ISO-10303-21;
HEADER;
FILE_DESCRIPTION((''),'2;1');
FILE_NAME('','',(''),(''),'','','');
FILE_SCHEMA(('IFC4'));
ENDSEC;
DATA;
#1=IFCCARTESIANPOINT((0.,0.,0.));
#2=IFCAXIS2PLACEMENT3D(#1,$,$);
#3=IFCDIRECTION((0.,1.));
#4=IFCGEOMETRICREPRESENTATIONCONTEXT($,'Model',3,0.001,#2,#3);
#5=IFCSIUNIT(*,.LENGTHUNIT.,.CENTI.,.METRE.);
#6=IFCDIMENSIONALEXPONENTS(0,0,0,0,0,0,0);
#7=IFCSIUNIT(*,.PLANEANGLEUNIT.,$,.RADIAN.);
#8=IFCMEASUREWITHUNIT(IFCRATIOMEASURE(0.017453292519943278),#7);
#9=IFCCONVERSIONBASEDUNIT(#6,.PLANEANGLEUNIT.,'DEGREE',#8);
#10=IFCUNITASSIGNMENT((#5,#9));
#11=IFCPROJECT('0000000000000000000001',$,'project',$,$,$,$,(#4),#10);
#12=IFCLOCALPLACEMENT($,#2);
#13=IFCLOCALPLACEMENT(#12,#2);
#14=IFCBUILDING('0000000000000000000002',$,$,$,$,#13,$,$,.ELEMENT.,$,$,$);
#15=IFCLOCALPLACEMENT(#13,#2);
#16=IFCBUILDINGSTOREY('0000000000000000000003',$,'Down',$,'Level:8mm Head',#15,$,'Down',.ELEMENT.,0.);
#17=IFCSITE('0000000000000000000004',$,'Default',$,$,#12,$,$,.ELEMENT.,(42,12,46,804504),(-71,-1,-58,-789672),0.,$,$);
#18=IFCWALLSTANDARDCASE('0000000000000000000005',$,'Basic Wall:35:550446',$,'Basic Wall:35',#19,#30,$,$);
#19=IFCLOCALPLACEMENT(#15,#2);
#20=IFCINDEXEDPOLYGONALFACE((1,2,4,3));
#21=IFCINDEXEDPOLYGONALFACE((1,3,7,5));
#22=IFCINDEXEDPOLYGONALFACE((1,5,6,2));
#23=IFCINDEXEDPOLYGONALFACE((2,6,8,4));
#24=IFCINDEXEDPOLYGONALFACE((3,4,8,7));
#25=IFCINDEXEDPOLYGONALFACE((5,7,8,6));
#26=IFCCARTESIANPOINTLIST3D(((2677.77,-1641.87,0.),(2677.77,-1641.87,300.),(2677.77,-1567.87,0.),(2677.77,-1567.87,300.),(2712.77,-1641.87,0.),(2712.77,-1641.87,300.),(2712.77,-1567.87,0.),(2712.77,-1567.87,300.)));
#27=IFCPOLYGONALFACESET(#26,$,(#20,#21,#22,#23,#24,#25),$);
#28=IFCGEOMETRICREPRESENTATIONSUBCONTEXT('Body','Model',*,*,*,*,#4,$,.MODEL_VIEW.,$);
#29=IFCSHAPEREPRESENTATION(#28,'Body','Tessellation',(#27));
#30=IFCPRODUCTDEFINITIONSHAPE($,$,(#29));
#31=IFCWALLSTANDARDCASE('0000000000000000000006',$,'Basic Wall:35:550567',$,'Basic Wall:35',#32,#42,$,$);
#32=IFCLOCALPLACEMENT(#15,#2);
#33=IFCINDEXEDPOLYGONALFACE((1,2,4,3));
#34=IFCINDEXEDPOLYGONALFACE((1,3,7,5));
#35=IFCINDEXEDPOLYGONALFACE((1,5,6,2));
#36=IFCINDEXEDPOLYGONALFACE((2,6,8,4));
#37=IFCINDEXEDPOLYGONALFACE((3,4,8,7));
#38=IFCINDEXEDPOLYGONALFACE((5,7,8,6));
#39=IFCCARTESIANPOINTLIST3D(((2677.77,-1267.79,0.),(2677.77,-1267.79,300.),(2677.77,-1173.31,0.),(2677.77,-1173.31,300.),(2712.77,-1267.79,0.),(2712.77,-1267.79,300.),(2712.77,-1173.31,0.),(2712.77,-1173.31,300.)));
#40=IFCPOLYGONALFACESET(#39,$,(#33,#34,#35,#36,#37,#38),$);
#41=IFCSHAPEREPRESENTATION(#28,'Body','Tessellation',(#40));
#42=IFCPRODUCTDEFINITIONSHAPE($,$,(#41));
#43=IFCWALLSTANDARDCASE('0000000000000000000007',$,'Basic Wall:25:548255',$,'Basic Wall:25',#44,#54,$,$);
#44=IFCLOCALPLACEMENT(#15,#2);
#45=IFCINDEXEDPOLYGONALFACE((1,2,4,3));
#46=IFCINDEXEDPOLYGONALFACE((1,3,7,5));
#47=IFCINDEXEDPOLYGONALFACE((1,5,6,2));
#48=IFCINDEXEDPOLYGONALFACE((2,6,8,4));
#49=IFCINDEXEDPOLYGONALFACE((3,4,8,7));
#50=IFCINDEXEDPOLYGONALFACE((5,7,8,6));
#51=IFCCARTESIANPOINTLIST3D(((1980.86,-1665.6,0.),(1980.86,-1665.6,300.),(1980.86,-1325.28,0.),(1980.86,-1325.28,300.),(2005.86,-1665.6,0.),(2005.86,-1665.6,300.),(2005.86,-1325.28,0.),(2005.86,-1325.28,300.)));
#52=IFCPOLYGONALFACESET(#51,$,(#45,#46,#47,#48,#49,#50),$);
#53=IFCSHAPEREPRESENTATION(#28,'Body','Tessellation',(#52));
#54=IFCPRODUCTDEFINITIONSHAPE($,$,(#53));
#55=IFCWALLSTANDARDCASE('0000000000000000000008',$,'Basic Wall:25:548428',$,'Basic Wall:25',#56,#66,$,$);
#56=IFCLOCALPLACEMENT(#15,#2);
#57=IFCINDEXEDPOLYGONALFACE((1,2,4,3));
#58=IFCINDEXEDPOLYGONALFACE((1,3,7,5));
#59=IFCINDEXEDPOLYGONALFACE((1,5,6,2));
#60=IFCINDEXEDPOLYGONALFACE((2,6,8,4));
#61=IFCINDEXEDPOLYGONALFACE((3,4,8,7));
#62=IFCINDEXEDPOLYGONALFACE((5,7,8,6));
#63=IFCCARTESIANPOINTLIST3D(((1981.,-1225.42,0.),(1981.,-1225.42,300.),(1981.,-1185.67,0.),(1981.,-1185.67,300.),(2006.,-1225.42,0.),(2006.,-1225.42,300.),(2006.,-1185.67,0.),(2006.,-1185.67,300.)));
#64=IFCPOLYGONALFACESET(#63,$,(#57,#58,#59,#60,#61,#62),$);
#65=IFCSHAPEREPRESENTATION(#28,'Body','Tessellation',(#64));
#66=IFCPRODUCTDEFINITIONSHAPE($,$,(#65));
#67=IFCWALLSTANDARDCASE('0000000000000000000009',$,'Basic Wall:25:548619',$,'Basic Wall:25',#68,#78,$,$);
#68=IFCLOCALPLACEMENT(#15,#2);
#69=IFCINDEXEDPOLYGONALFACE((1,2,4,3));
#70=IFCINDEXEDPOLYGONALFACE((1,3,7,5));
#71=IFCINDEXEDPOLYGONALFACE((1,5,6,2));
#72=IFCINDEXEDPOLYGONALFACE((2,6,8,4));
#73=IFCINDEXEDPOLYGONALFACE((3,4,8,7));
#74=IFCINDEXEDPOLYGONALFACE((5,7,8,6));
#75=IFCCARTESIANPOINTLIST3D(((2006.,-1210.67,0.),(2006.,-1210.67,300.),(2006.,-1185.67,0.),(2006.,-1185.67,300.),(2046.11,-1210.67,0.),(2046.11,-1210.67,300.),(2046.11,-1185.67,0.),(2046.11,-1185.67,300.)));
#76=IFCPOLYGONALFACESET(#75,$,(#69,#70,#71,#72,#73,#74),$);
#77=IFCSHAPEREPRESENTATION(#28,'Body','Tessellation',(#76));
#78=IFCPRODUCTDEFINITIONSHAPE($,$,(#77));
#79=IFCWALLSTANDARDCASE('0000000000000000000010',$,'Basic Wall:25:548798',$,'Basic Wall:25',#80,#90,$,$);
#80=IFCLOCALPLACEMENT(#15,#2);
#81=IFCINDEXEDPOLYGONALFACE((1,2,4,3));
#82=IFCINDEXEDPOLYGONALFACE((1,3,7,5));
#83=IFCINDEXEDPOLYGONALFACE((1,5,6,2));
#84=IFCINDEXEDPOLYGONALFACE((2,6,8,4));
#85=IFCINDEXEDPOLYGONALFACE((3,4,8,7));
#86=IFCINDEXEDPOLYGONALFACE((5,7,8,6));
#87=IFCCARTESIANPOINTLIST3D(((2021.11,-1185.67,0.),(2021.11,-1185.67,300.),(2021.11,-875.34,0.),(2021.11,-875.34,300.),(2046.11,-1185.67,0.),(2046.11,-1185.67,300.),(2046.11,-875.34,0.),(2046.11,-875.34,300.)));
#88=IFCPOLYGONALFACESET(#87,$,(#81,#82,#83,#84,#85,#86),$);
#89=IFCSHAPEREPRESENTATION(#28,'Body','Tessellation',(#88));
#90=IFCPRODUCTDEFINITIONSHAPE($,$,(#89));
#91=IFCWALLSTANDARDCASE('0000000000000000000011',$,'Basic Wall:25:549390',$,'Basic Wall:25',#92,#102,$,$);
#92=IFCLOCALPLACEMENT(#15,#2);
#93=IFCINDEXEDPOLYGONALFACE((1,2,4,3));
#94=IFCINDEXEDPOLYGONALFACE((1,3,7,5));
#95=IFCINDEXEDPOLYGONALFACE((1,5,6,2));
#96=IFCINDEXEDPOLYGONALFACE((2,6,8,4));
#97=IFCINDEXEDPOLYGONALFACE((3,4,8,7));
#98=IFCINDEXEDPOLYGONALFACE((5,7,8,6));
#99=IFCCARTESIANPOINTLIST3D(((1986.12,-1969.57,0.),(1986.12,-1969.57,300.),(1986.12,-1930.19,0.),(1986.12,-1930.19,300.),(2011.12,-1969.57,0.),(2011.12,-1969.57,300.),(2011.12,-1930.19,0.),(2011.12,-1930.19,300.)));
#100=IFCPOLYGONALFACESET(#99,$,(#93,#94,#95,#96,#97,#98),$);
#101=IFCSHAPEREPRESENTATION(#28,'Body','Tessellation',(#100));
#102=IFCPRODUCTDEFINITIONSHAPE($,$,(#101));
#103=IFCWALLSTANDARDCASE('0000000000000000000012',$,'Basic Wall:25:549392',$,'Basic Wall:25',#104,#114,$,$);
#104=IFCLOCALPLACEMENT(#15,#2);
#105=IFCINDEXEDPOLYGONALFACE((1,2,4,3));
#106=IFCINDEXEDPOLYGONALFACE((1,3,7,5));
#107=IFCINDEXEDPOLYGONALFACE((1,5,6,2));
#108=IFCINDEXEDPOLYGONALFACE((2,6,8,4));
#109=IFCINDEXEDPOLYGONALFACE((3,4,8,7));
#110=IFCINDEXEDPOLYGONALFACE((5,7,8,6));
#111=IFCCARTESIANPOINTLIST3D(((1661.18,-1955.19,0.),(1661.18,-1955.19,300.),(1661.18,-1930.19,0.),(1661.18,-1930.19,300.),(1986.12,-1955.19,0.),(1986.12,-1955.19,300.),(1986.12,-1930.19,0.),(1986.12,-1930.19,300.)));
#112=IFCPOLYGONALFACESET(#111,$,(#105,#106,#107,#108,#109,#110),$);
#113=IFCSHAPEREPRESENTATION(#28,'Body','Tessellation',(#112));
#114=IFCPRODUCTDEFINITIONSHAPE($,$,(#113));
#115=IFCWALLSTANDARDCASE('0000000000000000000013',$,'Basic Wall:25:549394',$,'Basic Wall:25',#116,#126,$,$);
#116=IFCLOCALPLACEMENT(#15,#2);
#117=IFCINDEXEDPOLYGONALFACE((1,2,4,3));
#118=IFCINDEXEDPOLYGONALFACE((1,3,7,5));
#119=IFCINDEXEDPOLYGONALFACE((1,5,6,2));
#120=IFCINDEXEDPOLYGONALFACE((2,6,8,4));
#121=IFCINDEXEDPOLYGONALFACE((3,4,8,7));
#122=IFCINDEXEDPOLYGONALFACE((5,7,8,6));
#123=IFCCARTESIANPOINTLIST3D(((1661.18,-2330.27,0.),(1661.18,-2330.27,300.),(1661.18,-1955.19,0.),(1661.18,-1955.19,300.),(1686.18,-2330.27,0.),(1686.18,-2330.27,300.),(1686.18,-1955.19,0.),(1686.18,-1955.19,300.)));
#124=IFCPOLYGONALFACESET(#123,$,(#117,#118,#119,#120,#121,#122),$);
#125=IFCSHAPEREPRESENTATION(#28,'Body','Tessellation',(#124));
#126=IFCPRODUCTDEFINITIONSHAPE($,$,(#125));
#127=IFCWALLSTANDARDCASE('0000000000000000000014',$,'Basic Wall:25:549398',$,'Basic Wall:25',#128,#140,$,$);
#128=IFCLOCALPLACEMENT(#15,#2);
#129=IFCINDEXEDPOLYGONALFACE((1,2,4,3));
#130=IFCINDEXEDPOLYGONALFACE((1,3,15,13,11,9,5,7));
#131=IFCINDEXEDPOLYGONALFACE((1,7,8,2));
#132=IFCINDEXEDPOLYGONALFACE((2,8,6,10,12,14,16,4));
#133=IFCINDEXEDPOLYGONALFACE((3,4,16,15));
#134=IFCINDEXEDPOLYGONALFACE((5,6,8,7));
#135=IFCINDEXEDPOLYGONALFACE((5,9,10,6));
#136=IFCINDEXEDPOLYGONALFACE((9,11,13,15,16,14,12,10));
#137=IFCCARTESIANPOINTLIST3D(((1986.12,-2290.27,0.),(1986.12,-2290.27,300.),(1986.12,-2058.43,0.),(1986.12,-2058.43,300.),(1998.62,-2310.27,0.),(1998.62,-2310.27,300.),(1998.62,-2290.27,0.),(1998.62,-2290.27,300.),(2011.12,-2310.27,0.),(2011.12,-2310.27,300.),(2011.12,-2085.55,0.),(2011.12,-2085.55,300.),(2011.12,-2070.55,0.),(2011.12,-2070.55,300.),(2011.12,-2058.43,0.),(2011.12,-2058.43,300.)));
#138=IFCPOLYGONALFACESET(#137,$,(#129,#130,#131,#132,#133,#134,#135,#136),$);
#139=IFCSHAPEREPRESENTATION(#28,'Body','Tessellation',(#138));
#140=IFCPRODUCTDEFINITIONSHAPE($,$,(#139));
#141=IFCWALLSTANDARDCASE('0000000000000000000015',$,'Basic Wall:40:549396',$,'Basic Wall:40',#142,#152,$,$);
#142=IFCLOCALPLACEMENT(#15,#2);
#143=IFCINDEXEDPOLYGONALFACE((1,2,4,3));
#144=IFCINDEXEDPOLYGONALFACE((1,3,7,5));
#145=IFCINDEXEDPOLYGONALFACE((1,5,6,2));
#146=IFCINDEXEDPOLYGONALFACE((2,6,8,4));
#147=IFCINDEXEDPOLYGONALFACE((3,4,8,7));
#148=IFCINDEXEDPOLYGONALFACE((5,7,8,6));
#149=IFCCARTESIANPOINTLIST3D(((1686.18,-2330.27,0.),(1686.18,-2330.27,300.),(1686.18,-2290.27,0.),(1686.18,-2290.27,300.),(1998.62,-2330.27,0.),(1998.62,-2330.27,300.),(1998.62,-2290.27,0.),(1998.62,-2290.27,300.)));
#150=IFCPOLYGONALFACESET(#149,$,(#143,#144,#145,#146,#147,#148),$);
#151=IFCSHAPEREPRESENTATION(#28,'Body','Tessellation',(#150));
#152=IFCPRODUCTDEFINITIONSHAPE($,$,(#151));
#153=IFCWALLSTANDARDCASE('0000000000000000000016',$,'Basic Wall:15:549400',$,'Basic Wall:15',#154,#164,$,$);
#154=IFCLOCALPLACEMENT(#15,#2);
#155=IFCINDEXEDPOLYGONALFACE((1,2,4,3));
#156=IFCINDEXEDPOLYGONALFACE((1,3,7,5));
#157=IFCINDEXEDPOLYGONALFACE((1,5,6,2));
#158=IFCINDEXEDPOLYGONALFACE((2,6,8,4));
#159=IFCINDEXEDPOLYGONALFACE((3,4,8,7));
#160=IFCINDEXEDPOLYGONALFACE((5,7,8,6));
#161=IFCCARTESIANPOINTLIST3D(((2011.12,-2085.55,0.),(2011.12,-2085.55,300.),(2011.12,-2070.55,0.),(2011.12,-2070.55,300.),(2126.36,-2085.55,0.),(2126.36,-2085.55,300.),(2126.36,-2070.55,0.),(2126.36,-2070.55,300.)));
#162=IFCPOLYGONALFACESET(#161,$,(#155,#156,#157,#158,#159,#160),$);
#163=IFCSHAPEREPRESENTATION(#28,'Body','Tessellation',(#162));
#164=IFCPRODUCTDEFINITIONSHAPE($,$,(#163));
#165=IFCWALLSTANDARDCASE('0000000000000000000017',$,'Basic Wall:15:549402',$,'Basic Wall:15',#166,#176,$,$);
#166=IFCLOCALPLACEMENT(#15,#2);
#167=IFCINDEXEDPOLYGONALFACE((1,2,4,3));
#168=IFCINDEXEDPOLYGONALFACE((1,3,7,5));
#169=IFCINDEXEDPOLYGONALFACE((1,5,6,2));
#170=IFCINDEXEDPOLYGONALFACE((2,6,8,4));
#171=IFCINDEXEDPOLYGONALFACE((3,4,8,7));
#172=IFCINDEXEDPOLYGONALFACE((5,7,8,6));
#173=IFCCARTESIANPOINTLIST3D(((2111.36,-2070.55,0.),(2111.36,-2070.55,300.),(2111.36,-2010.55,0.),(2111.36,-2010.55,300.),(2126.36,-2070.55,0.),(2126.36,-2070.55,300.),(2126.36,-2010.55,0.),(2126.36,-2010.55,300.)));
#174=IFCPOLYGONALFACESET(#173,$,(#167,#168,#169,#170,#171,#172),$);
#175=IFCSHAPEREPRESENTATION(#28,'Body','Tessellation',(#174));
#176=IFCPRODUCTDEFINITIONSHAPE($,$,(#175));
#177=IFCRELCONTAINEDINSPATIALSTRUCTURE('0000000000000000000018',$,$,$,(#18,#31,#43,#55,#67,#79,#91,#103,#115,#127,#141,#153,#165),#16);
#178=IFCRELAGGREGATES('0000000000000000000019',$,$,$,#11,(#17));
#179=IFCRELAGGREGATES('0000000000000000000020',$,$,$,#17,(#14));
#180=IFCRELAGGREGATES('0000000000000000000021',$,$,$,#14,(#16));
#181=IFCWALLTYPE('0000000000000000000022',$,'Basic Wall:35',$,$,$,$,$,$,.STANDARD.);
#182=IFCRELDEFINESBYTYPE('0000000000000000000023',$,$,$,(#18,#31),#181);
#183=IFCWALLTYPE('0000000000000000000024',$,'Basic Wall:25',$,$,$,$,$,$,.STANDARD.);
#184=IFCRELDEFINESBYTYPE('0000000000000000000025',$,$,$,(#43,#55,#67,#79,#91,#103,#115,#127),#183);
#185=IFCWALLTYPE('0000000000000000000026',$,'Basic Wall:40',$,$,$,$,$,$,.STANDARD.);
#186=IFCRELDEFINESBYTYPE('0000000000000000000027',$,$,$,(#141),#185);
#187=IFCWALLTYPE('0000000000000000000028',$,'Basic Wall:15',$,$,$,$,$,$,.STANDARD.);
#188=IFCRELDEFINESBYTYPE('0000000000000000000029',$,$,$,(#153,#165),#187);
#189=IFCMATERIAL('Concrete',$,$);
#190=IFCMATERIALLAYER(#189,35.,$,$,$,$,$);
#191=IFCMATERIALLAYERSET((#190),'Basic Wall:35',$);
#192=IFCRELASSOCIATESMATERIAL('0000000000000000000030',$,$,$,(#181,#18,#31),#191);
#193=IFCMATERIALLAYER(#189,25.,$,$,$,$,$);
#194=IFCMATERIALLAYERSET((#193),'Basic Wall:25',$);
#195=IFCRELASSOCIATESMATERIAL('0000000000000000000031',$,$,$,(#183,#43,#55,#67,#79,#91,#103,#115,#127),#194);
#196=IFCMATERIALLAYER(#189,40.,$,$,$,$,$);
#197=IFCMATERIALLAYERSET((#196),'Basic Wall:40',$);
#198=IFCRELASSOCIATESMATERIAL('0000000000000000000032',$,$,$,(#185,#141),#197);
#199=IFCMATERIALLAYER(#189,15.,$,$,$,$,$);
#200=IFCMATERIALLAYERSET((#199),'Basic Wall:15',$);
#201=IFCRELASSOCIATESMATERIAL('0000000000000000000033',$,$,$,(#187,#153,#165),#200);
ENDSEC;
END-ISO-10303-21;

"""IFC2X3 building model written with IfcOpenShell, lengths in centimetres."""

from ifc_helpers import new_model, entity, si_unit, converted_unit, direction, frame, frame_2d, origin, place, context, subcontext, project, spatial, polyline, rectangle, outline, extrude, material, layer, layer_set, layer_usage, type_object, element, save


model = new_model("IFC2X3")

# Units and contexts
model_context = context("Model", 3, precision=0.001, world=origin(), true_north=direction((0.0, 1.0)))
body_context = subcontext(model_context, "Body", "Model", "MODEL_VIEW")
ifc_project = project(units=[si_unit("LENGTHUNIT", "METRE", prefix="CENTI"), converted_unit("PLANEANGLEUNIT", "DEGREE", entity("IfcRatioMeasure", 0.017453292519943278), si_unit("PLANEANGLEUNIT", "RADIAN"), dimensions=[0, 0, 0, 0, 0, 0, 0])], contexts=[model_context])

# Site, building, storey
site_placement = place(None, origin())
site = spatial("IfcSite", under=ifc_project, at=site_placement, Name="Default", CompositionType="ELEMENT", RefLatitude=(42, 12, 46, 804504), RefLongitude=(-71, -1, -58, -789672), RefElevation=0.0)
building_placement = place(site_placement, origin())
building = spatial("IfcBuilding", under=site, at=building_placement, CompositionType="ELEMENT")
storey_placement = place(building_placement, origin())
storey = spatial("IfcBuildingStorey", under=building, at=storey_placement, Name="Down", ObjectType="Level:8mm Head", LongName="Down", CompositionType="ELEMENT", Elevation=0.0)

# Walls
ifc_material = material(Name="Concrete")
ifc_layer_1 = layer(ifc_material, 35.0)
ifc_layer_set_1 = layer_set([ifc_layer_1], Name="Basic Wall:35")
ifc_layer_usage_1 = layer_usage(ifc_layer_set_1, "AXIS2", "POSITIVE", -17.5)
wall_type_1 = type_object("IfcWallType", Name="Basic Wall:35", PredefinedType="STANDARD", material=ifc_layer_set_1)
wall_1_placement = place(storey_placement, frame((2695.27, -1641.87, 0.0), z_axis=(0.0, 0.0, 1.0), x_axis=(0.0, 1.0, 0.0)))
element("IfcWallStandardCase", 1, at=wall_1_placement, inside=storey, type_object=wall_type_1, material=ifc_layer_usage_1, Name="Basic Wall:35:550446", ObjectType="Basic Wall:35", context=body_context, shape_type="SweptSolid", body=[
    extrude(rectangle(XDim=74.0, YDim=35.0, at=frame_2d((37.0, 0.0), x_axis=(-1.0, 0.0))), origin(), (0.0, 0.0, 1.0), 300.0),
])
ifc_layer_usage_2 = layer_usage(ifc_layer_set_1, "AXIS2", "POSITIVE", -17.5)
wall_2_placement = place(storey_placement, frame((2695.27, -1267.79, 0.0), z_axis=(0.0, 0.0, 1.0), x_axis=(0.0, 1.0, 0.0)))
element("IfcWallStandardCase", 2, at=wall_2_placement, inside=storey, type_object=wall_type_1, material=ifc_layer_usage_2, Name="Basic Wall:35:550567", ObjectType="Basic Wall:35", context=body_context, shape_type="SweptSolid", body=[
    extrude(rectangle(XDim=94.48, YDim=35.0, at=frame_2d((47.24, 0.0), x_axis=(-1.0, 0.0))), origin(), (0.0, 0.0, 1.0), 300.0),
])
ifc_layer_2 = layer(ifc_material, 25.0)
ifc_layer_set_2 = layer_set([ifc_layer_2], Name="Basic Wall:25")
ifc_layer_usage_3 = layer_usage(ifc_layer_set_2, "AXIS2", "POSITIVE", -12.5)
wall_type_2 = type_object("IfcWallType", Name="Basic Wall:25", PredefinedType="STANDARD", material=ifc_layer_set_2)
wall_3_placement = place(storey_placement, frame((1993.36, -1665.6, 0.0), z_axis=(0.0, 0.0, 1.0), x_axis=(0.0, 1.0, 0.0)))
element("IfcWallStandardCase", 3, at=wall_3_placement, inside=storey, type_object=wall_type_2, material=ifc_layer_usage_3, Name="Basic Wall:25:548255", ObjectType="Basic Wall:25", context=body_context, shape_type="SweptSolid", body=[
    extrude(rectangle(XDim=340.32, YDim=25.0, at=frame_2d((170.16, 0.0), x_axis=(-1.0, 0.0))), origin(), (0.0, 0.0, 1.0), 300.0),
])
ifc_layer_usage_4 = layer_usage(ifc_layer_set_2, "AXIS2", "NEGATIVE", 12.5)
wall_4_placement = place(storey_placement, frame((1993.5, -1225.42, 0.0), z_axis=(0.0, 0.0, 1.0), x_axis=(0.0, 1.0, 0.0)))
element("IfcWallStandardCase", 4, at=wall_4_placement, inside=storey, type_object=wall_type_2, material=ifc_layer_usage_4, Name="Basic Wall:25:548428", ObjectType="Basic Wall:25", context=body_context, shape_type="SweptSolid", body=[
    extrude(rectangle(XDim=39.75, YDim=25.0, at=frame_2d((19.88, 0.0), x_axis=(-1.0, 0.0))), origin(), (0.0, 0.0, 1.0), 300.0),
])
ifc_layer_usage_5 = layer_usage(ifc_layer_set_2, "AXIS2", "NEGATIVE", 12.5)
wall_5_placement = place(storey_placement, frame((2006.0, -1198.17, 0.0)))
element("IfcWallStandardCase", 5, at=wall_5_placement, inside=storey, type_object=wall_type_2, material=ifc_layer_usage_5, Name="Basic Wall:25:548619", ObjectType="Basic Wall:25", context=body_context, shape_type="SweptSolid", body=[
    extrude(rectangle(XDim=40.11, YDim=25.0, at=frame_2d((20.06, 0.0), x_axis=(-1.0, 0.0))), origin(), (0.0, 0.0, 1.0), 300.0),
])
ifc_layer_usage_6 = layer_usage(ifc_layer_set_2, "AXIS2", "POSITIVE", -12.5)
wall_6_placement = place(storey_placement, frame((2033.61, -1185.67, 0.0), z_axis=(0.0, 0.0, 1.0), x_axis=(0.0, 1.0, 0.0)))
element("IfcWallStandardCase", 6, at=wall_6_placement, inside=storey, type_object=wall_type_2, material=ifc_layer_usage_6, Name="Basic Wall:25:548798", ObjectType="Basic Wall:25", context=body_context, shape_type="SweptSolid", body=[
    extrude(rectangle(XDim=310.33, YDim=25.0, at=frame_2d((155.17, 0.0), x_axis=(-1.0, 0.0))), origin(), (0.0, 0.0, 1.0), 300.0),
])
ifc_layer_usage_7 = layer_usage(ifc_layer_set_2, "AXIS2", "POSITIVE", -12.5)
wall_7_placement = place(storey_placement, frame((1998.62, -1969.57, 0.0), z_axis=(0.0, 0.0, 1.0), x_axis=(0.0, 1.0, 0.0)))
element("IfcWallStandardCase", 7, at=wall_7_placement, inside=storey, type_object=wall_type_2, material=ifc_layer_usage_7, Name="Basic Wall:25:549390", ObjectType="Basic Wall:25", context=body_context, shape_type="SweptSolid", body=[
    extrude(rectangle(XDim=39.38, YDim=25.0, at=frame_2d((19.69, 0.0), x_axis=(-1.0, 0.0))), origin(), (0.0, 0.0, 1.0), 300.0),
])
ifc_layer_usage_8 = layer_usage(ifc_layer_set_2, "AXIS2", "POSITIVE", -12.5)
wall_8_placement = place(storey_placement, frame((1986.12, -1942.69, 0.0), z_axis=(0.0, 0.0, 1.0), x_axis=(-1.0, 0.0, 0.0)))
element("IfcWallStandardCase", 8, at=wall_8_placement, inside=storey, type_object=wall_type_2, material=ifc_layer_usage_8, Name="Basic Wall:25:549392", ObjectType="Basic Wall:25", context=body_context, shape_type="SweptSolid", body=[
    extrude(rectangle(XDim=324.94, YDim=25.0, at=frame_2d((162.47, 0.0), x_axis=(-1.0, 0.0))), origin(), (0.0, 0.0, 1.0), 300.0),
])
ifc_layer_usage_9 = layer_usage(ifc_layer_set_2, "AXIS2", "POSITIVE", -12.5)
wall_9_placement = place(storey_placement, frame((1673.68, -1955.19, 0.0), z_axis=(0.0, 0.0, 1.0), x_axis=(0.0, -1.0, 0.0)))
element("IfcWallStandardCase", 9, at=wall_9_placement, inside=storey, type_object=wall_type_2, material=ifc_layer_usage_9, Name="Basic Wall:25:549394", ObjectType="Basic Wall:25", context=body_context, shape_type="SweptSolid", body=[
    extrude(rectangle(XDim=375.08, YDim=25.0, at=frame_2d((187.54, 0.0), x_axis=(-1.0, 0.0))), origin(), (0.0, 0.0, 1.0), 300.0),
])
ifc_layer_usage_10 = layer_usage(ifc_layer_set_2, "AXIS2", "POSITIVE", -12.5)
wall_10_placement = place(storey_placement, frame((1998.62, -2310.27, 0.0), z_axis=(0.0, 0.0, 1.0), x_axis=(0.0, 1.0, 0.0)))
element("IfcWallStandardCase", 10, at=wall_10_placement, inside=storey, type_object=wall_type_2, material=ifc_layer_usage_10, Name="Basic Wall:25:549398", ObjectType="Basic Wall:25", context=body_context, shape_type="SweptSolid", body=[
    extrude(outline(polyline([(251.85, -12.5), (251.85, 12.5), (20.0, 12.5), (20.0, 0.0), (0.0, 0.0), (0.0, -12.5), (224.72, -12.5), (239.72, -12.5), (251.85, -12.5)])), origin(), (0.0, 0.0, 1.0), 300.0),
])
ifc_layer_3 = layer(ifc_material, 40.0)
ifc_layer_set_3 = layer_set([ifc_layer_3], Name="Basic Wall:40")
ifc_layer_usage_11 = layer_usage(ifc_layer_set_3, "AXIS2", "POSITIVE", -20.0)
wall_type_3 = type_object("IfcWallType", Name="Basic Wall:40", PredefinedType="STANDARD", material=ifc_layer_set_3)
wall_11_placement = place(storey_placement, frame((1686.18, -2310.27, 0.0)))
element("IfcWallStandardCase", 11, at=wall_11_placement, inside=storey, type_object=wall_type_3, material=ifc_layer_usage_11, Name="Basic Wall:40:549396", ObjectType="Basic Wall:40", context=body_context, shape_type="SweptSolid", body=[
    extrude(rectangle(XDim=312.44, YDim=40.0, at=frame_2d((156.22, 0.0), x_axis=(-1.0, 0.0))), origin(), (0.0, 0.0, 1.0), 300.0),
])
ifc_layer_4 = layer(ifc_material, 15.0)
ifc_layer_set_4 = layer_set([ifc_layer_4], Name="Basic Wall:15")
ifc_layer_usage_12 = layer_usage(ifc_layer_set_4, "AXIS2", "POSITIVE", -7.5)
wall_type_4 = type_object("IfcWallType", Name="Basic Wall:15", PredefinedType="STANDARD", material=ifc_layer_set_4)
wall_12_placement = place(storey_placement, frame((2011.12, -2078.05, 0.0)))
element("IfcWallStandardCase", 12, at=wall_12_placement, inside=storey, type_object=wall_type_4, material=ifc_layer_usage_12, Name="Basic Wall:15:549400", ObjectType="Basic Wall:15", context=body_context, shape_type="SweptSolid", body=[
    extrude(rectangle(XDim=115.24, YDim=15.0, at=frame_2d((57.62, 0.0), x_axis=(-1.0, 0.0))), origin(), (0.0, 0.0, 1.0), 300.0),
])
ifc_layer_usage_13 = layer_usage(ifc_layer_set_4, "AXIS2", "POSITIVE", -7.5)
wall_13_placement = place(storey_placement, frame((2118.86, -2070.55, 0.0), z_axis=(0.0, 0.0, 1.0), x_axis=(0.0, 1.0, 0.0)))
element("IfcWallStandardCase", 13, at=wall_13_placement, inside=storey, type_object=wall_type_4, material=ifc_layer_usage_13, Name="Basic Wall:15:549402", ObjectType="Basic Wall:15", context=body_context, shape_type="SweptSolid", body=[
    extrude(rectangle(XDim=60.0, YDim=15.0, at=frame_2d((30.0, 0.0), x_axis=(-1.0, 0.0))), origin(), (0.0, 0.0, 1.0), 300.0),
])

save(model, "model.ifc")
